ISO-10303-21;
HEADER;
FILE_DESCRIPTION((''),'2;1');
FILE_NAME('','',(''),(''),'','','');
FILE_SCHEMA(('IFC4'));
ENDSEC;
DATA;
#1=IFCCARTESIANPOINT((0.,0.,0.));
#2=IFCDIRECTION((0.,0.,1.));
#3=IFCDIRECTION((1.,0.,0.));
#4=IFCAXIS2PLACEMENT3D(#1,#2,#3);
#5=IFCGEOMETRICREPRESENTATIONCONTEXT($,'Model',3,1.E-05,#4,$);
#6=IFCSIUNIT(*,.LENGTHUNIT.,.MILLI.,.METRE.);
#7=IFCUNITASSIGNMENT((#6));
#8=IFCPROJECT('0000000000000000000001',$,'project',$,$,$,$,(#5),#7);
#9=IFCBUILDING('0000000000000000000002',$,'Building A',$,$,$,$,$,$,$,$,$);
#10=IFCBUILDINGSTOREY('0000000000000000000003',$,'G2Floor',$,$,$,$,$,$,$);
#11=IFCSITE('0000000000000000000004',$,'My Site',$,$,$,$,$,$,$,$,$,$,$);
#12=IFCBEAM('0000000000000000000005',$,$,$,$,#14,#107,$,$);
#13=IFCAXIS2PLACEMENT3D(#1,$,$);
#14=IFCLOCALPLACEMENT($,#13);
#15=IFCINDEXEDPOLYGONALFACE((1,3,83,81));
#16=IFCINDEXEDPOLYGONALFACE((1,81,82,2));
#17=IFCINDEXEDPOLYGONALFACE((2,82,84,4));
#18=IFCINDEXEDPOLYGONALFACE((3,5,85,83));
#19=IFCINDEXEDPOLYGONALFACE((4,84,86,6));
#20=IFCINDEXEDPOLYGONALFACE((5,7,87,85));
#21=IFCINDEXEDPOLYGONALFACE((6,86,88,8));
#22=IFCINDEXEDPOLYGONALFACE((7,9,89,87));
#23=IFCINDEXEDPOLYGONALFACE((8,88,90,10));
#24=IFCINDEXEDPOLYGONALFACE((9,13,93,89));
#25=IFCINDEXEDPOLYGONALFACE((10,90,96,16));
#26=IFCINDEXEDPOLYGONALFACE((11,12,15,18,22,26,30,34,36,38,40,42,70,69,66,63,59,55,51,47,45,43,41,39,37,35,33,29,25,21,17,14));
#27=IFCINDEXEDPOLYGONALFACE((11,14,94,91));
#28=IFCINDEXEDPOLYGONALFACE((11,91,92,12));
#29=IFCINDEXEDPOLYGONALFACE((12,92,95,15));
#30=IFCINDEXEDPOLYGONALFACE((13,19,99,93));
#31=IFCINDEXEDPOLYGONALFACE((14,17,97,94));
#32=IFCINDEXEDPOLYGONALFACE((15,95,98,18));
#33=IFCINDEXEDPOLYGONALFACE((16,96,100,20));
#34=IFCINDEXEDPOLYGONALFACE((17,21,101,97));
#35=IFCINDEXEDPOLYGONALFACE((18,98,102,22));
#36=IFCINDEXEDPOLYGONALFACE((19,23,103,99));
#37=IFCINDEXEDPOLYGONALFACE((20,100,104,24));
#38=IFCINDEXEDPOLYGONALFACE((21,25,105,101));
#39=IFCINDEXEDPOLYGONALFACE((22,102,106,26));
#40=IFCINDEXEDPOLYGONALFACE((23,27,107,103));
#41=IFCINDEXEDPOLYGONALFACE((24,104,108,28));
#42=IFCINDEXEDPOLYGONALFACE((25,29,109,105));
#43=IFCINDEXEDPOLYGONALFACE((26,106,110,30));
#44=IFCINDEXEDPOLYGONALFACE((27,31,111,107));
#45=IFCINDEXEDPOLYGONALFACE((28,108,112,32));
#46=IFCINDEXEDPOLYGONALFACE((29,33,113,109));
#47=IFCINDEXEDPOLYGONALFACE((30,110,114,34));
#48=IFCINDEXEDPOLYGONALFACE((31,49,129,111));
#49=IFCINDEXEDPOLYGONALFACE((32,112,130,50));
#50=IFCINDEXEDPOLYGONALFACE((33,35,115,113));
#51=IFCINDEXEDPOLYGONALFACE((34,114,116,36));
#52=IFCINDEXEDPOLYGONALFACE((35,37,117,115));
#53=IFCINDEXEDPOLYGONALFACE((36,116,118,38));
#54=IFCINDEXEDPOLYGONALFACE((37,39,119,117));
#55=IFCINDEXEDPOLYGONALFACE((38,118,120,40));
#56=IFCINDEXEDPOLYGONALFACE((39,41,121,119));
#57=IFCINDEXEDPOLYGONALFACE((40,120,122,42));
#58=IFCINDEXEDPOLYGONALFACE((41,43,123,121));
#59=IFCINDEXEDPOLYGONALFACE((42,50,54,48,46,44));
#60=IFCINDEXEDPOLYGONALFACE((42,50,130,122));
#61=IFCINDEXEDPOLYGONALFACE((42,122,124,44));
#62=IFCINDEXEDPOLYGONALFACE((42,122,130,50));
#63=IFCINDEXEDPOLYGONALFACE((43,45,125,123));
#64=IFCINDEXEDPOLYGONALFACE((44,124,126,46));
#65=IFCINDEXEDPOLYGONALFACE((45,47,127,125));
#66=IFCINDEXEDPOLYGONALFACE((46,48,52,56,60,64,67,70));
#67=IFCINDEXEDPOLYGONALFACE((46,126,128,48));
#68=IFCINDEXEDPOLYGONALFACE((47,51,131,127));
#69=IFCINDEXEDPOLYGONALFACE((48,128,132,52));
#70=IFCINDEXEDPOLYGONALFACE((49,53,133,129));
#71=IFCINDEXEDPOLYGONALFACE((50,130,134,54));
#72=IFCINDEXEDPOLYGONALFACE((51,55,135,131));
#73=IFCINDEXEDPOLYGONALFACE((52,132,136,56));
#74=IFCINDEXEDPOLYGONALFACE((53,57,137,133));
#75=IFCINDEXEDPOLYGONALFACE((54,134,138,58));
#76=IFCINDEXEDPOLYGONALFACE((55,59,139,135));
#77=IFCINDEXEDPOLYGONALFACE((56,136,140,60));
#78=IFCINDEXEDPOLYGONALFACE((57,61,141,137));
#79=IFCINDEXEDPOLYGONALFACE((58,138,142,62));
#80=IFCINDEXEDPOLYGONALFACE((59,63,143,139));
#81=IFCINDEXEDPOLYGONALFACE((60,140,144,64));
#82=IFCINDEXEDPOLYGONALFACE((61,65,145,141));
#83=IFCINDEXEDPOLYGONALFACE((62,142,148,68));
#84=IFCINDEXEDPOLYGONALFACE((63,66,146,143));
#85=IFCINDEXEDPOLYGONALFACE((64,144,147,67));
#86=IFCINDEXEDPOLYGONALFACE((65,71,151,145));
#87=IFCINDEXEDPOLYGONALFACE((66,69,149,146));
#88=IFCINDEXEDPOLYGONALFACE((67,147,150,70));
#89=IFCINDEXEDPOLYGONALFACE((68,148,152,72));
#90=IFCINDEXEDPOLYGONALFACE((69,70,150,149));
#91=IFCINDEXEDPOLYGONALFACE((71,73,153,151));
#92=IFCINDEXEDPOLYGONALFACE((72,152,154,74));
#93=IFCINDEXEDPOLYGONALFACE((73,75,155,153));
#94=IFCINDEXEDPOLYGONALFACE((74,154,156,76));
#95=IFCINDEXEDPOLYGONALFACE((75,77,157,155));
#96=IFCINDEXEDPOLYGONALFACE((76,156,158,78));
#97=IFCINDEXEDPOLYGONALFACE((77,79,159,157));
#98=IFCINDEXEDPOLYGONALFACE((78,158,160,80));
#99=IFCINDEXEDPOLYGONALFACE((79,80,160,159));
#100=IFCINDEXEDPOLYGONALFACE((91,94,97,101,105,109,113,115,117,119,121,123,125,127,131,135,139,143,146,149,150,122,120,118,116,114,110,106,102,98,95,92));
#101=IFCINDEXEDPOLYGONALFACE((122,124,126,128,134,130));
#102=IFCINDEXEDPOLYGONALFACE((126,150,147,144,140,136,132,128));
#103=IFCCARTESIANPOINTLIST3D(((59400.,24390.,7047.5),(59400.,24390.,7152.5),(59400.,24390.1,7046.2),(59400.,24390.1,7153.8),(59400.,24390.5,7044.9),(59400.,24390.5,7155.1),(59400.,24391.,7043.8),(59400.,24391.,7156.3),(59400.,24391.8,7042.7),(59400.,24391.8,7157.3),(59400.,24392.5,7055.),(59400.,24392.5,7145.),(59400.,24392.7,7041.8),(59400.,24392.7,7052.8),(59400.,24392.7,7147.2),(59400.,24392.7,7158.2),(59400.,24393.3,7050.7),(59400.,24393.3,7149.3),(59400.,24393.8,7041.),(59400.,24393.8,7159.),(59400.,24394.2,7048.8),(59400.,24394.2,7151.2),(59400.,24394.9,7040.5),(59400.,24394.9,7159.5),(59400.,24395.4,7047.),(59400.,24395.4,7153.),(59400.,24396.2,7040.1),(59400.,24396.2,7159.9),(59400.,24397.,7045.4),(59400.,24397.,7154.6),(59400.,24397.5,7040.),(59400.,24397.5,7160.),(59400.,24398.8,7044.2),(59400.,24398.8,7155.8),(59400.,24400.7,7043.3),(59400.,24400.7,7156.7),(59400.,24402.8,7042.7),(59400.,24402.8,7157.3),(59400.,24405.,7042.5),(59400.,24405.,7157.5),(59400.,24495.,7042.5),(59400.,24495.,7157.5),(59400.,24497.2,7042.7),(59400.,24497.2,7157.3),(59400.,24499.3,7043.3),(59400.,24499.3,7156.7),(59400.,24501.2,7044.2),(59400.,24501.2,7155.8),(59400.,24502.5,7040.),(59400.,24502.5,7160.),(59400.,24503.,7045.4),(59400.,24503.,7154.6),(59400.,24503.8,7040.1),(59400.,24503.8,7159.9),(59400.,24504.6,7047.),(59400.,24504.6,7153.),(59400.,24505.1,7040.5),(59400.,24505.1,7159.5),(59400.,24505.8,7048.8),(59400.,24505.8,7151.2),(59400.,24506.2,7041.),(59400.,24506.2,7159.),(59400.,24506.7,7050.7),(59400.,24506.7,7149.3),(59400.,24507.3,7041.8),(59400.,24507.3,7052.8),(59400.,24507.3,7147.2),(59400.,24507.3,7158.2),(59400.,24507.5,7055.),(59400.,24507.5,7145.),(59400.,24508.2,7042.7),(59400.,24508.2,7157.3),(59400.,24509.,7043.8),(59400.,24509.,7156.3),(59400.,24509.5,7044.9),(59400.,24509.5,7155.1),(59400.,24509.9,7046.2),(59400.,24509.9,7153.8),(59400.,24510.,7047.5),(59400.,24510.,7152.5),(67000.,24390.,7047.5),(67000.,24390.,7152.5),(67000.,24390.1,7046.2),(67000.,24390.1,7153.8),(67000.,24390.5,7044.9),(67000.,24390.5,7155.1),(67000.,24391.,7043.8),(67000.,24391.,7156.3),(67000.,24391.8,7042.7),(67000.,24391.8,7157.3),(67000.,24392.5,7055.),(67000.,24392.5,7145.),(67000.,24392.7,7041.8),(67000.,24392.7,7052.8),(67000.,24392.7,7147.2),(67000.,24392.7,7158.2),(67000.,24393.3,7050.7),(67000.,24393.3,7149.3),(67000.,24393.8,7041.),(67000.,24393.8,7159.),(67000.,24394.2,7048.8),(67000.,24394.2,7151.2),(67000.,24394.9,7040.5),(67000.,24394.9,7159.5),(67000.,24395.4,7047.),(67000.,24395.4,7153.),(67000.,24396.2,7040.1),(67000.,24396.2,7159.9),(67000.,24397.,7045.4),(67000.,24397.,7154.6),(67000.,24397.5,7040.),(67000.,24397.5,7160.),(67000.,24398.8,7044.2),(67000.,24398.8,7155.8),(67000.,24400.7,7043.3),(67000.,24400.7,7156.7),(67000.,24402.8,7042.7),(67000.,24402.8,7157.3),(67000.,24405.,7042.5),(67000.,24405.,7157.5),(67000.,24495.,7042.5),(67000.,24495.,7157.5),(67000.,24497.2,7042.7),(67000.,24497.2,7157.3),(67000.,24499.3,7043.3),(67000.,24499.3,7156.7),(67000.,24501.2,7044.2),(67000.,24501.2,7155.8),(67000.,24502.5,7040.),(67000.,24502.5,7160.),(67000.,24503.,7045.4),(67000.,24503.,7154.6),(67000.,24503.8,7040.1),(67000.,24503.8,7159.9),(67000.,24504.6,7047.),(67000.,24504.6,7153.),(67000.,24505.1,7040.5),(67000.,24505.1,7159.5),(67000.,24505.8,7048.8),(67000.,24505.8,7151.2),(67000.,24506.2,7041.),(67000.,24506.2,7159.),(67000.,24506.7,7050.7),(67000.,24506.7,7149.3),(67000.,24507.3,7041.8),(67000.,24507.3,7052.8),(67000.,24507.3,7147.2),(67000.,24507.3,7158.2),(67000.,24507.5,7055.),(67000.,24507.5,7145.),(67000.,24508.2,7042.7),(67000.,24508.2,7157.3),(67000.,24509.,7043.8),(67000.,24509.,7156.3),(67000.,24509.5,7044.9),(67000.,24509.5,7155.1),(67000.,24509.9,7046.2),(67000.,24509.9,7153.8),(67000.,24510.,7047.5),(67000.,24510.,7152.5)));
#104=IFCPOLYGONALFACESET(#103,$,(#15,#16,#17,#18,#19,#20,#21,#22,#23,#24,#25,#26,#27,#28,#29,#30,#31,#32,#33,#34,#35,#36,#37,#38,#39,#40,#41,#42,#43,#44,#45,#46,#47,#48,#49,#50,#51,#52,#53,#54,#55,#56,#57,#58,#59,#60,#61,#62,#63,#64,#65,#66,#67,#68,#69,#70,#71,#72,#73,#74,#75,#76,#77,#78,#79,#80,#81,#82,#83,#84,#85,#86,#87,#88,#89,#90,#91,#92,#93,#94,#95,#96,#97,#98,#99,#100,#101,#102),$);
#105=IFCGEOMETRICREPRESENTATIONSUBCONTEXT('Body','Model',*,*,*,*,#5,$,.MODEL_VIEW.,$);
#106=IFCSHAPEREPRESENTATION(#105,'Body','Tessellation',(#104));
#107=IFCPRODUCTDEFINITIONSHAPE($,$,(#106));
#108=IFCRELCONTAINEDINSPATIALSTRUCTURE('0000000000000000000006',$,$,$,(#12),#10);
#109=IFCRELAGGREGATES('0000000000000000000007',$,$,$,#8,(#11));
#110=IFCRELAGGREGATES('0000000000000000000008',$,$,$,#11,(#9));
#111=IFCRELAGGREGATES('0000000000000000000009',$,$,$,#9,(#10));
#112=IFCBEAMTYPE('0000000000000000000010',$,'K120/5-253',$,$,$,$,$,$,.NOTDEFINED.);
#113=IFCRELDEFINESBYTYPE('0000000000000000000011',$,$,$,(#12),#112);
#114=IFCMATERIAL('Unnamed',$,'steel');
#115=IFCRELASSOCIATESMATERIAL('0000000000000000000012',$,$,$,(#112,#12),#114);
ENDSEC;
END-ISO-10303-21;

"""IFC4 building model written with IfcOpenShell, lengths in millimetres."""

from ifc_helpers import new_model, si_unit, frame, origin_with_axes, place, context, subcontext, project, spatial, polyline, outline, extrude, material, material_profile, profile_set, profile_usage, type_object, element, save


model = new_model("IFC4")

# Units and contexts
model_context = context("Model", 3, precision=1e-05, world=origin_with_axes())
body_context = subcontext(model_context, "Body", "Model", "MODEL_VIEW")
ifc_project = project(units=[si_unit("LENGTHUNIT", "METRE", prefix="MILLI")], contexts=[model_context])

# Site, building, storey
site = spatial("IfcSite", under=ifc_project, Name="My Site")
building = spatial("IfcBuilding", under=site, Name="Building A")
storey = spatial("IfcBuildingStorey", under=building, Name="G2Floor")

# Beam
ifc_material_1 = material(Name="Unnamed", Category="steel")
ifc_material_profile_1 = material_profile(ifc_material_1, outline(polyline([(-52.5, -60.0), (52.5, -60.0), (52.5, -60.0), (53.8, -59.9), (53.8, -59.9), (55.1, -59.5), (55.1, -59.5), (56.2, -59.0), (56.2, -59.0), (57.3, -58.2), (57.3, -58.2), (58.2, -57.3), (58.2, -57.3), (59.0, -56.2), (59.0, -56.2), (59.5, -55.1), (59.5, -55.1), (59.9, -53.8), (59.9, -53.8), (60.0, -52.5), (60.0, -52.5), (60.0, 52.5), (60.0, 52.5), (59.9, 53.8), (59.9, 53.8), (59.5, 55.1), (59.5, 55.1), (59.0, 56.2), (59.0, 56.2), (58.2, 57.3), (58.2, 57.3), (57.3, 58.2), (57.3, 58.2), (56.2, 59.0), (56.2, 59.0), (55.1, 59.5), (55.1, 59.5), (53.8, 59.9), (53.8, 59.9), (52.5, 60.0), (52.5, 60.0), (-52.5, 60.0), (-52.5, 60.0), (-53.8, 59.9), (-53.8, 59.9), (-55.1, 59.5), (-55.1, 59.5), (-56.2, 59.0), (-56.2, 59.0), (-57.3, 58.2), (-57.3, 58.2), (-58.2, 57.3), (-58.2, 57.3), (-59.0, 56.2), (-59.0, 56.2), (-59.5, 55.1), (-59.5, 55.1), (-59.9, 53.8), (-59.9, 53.8), (-60.0, 52.5), (-60.0, 52.5), (-60.0, -52.5), (-60.0, -52.5), (-59.9, -53.8), (-59.9, -53.8), (-59.5, -55.1), (-59.5, -55.1), (-59.0, -56.2), (-59.0, -56.2), (-58.2, -57.3), (-58.2, -57.3), (-57.3, -58.2), (-57.3, -58.2), (-56.2, -59.0), (-56.2, -59.0), (-55.1, -59.5), (-55.1, -59.5), (-53.8, -59.9), (-53.8, -59.9), (-52.5, -60.0), (-52.5, -60.0), (-45.0, -57.5), (-45.0, -57.5), (45.0, -57.5), (45.0, -57.5), (47.2, -57.3), (47.2, -57.3), (49.3, -56.7), (49.3, -56.7), (51.2, -55.8), (51.2, -55.8), (53.0, -54.6), (53.0, -54.6), (54.6, -53.0), (54.6, -53.0), (55.8, -51.2), (55.8, -51.2), (56.7, -49.3), (56.7, -49.3), (57.3, -47.2), (57.3, -47.2), (57.5, -45.0), (57.5, -45.0), (57.5, 45.0), (57.5, 45.0), (57.3, 47.2), (57.3, 47.2), (56.7, 49.3), (56.7, 49.3), (55.8, 51.2), (55.8, 51.2), (54.6, 53.0), (54.6, 53.0), (53.0, 54.6), (53.0, 54.6), (51.2, 55.8), (51.2, 55.8), (49.3, 56.7), (49.3, 56.7), (47.2, 57.3), (47.2, 57.3), (45.0, 57.5), (45.0, 57.5), (-45.0, 57.5), (-45.0, 57.5), (-47.2, 57.3), (-47.2, 57.3), (-49.3, 56.7), (-49.3, 56.7), (-51.2, 55.8), (-51.2, 55.8), (-53.0, 54.6), (-53.0, 54.6), (-54.6, 53.0), (-54.6, 53.0), (-55.8, 51.2), (-55.8, 51.2), (-56.7, 49.3), (-56.7, 49.3), (-57.3, 47.2), (-57.3, 47.2), (-57.5, 45.0), (-57.5, 45.0), (-57.5, -45.0), (-57.5, -45.0), (-57.3, -47.2), (-57.3, -47.2), (-56.7, -49.3), (-56.7, -49.3), (-55.8, -51.2), (-55.8, -51.2), (-54.6, -53.0), (-54.6, -53.0), (-53.0, -54.6), (-53.0, -54.6), (-51.2, -55.8), (-51.2, -55.8), (-49.3, -56.7), (-49.3, -56.7), (-47.2, -57.3), (-47.2, -57.3), (-45.0, -57.5), (-45.0, -57.5), (-52.5, -60.0)])))
ifc_profile_set_1 = profile_set([ifc_material_profile_1], Name="K120/5-253")
ifc_profile_usage_1 = profile_usage(ifc_profile_set_1)
beam_type_1 = type_object("IfcBeamType", Name="K120/5-253", PredefinedType="NOTDEFINED", material=ifc_profile_set_1)
beam_1_placement = place(None, frame((59400.0, 24450.0, 7100.0), z_axis=(1.0, 0.0, 0.0), x_axis=(0.0, -1.0, 0.0)))
element("IfcBeam", 1, at=beam_1_placement, inside=storey, type_object=beam_type_1, material=ifc_profile_usage_1, context=body_context, shape_type="SweptSolid", body=[
    extrude(outline(polyline([(-52.5, -60.0), (52.5, -60.0), (52.5, -60.0), (53.8, -59.9), (53.8, -59.9), (55.1, -59.5), (55.1, -59.5), (56.2, -59.0), (56.2, -59.0), (57.3, -58.2), (57.3, -58.2), (58.2, -57.3), (58.2, -57.3), (59.0, -56.2), (59.0, -56.2), (59.5, -55.1), (59.5, -55.1), (59.9, -53.8), (59.9, -53.8), (60.0, -52.5), (60.0, -52.5), (60.0, 52.5), (60.0, 52.5), (59.9, 53.8), (59.9, 53.8), (59.5, 55.1), (59.5, 55.1), (59.0, 56.2), (59.0, 56.2), (58.2, 57.3), (58.2, 57.3), (57.3, 58.2), (57.3, 58.2), (56.2, 59.0), (56.2, 59.0), (55.1, 59.5), (55.1, 59.5), (53.8, 59.9), (53.8, 59.9), (52.5, 60.0), (52.5, 60.0), (-52.5, 60.0), (-52.5, 60.0), (-53.8, 59.9), (-53.8, 59.9), (-55.1, 59.5), (-55.1, 59.5), (-56.2, 59.0), (-56.2, 59.0), (-57.3, 58.2), (-57.3, 58.2), (-58.2, 57.3), (-58.2, 57.3), (-59.0, 56.2), (-59.0, 56.2), (-59.5, 55.1), (-59.5, 55.1), (-59.9, 53.8), (-59.9, 53.8), (-60.0, 52.5), (-60.0, 52.5), (-60.0, -52.5), (-60.0, -52.5), (-59.9, -53.8), (-59.9, -53.8), (-59.5, -55.1), (-59.5, -55.1), (-59.0, -56.2), (-59.0, -56.2), (-58.2, -57.3), (-58.2, -57.3), (-57.3, -58.2), (-57.3, -58.2), (-56.2, -59.0), (-56.2, -59.0), (-55.1, -59.5), (-55.1, -59.5), (-53.8, -59.9), (-53.8, -59.9), (-52.5, -60.0), (-52.5, -60.0), (-45.0, -57.5), (-45.0, -57.5), (45.0, -57.5), (45.0, -57.5), (47.2, -57.3), (47.2, -57.3), (49.3, -56.7), (49.3, -56.7), (51.2, -55.8), (51.2, -55.8), (53.0, -54.6), (53.0, -54.6), (54.6, -53.0), (54.6, -53.0), (55.8, -51.2), (55.8, -51.2), (56.7, -49.3), (56.7, -49.3), (57.3, -47.2), (57.3, -47.2), (57.5, -45.0), (57.5, -45.0), (57.5, 45.0), (57.5, 45.0), (57.3, 47.2), (57.3, 47.2), (56.7, 49.3), (56.7, 49.3), (55.8, 51.2), (55.8, 51.2), (54.6, 53.0), (54.6, 53.0), (53.0, 54.6), (53.0, 54.6), (51.2, 55.8), (51.2, 55.8), (49.3, 56.7), (49.3, 56.7), (47.2, 57.3), (47.2, 57.3), (45.0, 57.5), (45.0, 57.5), (-45.0, 57.5), (-45.0, 57.5), (-47.2, 57.3), (-47.2, 57.3), (-49.3, 56.7), (-49.3, 56.7), (-51.2, 55.8), (-51.2, 55.8), (-53.0, 54.6), (-53.0, 54.6), (-54.6, 53.0), (-54.6, 53.0), (-55.8, 51.2), (-55.8, 51.2), (-56.7, 49.3), (-56.7, 49.3), (-57.3, 47.2), (-57.3, 47.2), (-57.5, 45.0), (-57.5, 45.0), (-57.5, -45.0), (-57.5, -45.0), (-57.3, -47.2), (-57.3, -47.2), (-56.7, -49.3), (-56.7, -49.3), (-55.8, -51.2), (-55.8, -51.2), (-54.6, -53.0), (-54.6, -53.0), (-53.0, -54.6), (-53.0, -54.6), (-51.2, -55.8), (-51.2, -55.8), (-49.3, -56.7), (-49.3, -56.7), (-47.2, -57.3), (-47.2, -57.3), (-45.0, -57.5), (-45.0, -57.5), (-52.5, -60.0)])), origin_with_axes(), (0.0, 0.0, 1.0), 7600.0),
])

save(model, "model.ifc")
